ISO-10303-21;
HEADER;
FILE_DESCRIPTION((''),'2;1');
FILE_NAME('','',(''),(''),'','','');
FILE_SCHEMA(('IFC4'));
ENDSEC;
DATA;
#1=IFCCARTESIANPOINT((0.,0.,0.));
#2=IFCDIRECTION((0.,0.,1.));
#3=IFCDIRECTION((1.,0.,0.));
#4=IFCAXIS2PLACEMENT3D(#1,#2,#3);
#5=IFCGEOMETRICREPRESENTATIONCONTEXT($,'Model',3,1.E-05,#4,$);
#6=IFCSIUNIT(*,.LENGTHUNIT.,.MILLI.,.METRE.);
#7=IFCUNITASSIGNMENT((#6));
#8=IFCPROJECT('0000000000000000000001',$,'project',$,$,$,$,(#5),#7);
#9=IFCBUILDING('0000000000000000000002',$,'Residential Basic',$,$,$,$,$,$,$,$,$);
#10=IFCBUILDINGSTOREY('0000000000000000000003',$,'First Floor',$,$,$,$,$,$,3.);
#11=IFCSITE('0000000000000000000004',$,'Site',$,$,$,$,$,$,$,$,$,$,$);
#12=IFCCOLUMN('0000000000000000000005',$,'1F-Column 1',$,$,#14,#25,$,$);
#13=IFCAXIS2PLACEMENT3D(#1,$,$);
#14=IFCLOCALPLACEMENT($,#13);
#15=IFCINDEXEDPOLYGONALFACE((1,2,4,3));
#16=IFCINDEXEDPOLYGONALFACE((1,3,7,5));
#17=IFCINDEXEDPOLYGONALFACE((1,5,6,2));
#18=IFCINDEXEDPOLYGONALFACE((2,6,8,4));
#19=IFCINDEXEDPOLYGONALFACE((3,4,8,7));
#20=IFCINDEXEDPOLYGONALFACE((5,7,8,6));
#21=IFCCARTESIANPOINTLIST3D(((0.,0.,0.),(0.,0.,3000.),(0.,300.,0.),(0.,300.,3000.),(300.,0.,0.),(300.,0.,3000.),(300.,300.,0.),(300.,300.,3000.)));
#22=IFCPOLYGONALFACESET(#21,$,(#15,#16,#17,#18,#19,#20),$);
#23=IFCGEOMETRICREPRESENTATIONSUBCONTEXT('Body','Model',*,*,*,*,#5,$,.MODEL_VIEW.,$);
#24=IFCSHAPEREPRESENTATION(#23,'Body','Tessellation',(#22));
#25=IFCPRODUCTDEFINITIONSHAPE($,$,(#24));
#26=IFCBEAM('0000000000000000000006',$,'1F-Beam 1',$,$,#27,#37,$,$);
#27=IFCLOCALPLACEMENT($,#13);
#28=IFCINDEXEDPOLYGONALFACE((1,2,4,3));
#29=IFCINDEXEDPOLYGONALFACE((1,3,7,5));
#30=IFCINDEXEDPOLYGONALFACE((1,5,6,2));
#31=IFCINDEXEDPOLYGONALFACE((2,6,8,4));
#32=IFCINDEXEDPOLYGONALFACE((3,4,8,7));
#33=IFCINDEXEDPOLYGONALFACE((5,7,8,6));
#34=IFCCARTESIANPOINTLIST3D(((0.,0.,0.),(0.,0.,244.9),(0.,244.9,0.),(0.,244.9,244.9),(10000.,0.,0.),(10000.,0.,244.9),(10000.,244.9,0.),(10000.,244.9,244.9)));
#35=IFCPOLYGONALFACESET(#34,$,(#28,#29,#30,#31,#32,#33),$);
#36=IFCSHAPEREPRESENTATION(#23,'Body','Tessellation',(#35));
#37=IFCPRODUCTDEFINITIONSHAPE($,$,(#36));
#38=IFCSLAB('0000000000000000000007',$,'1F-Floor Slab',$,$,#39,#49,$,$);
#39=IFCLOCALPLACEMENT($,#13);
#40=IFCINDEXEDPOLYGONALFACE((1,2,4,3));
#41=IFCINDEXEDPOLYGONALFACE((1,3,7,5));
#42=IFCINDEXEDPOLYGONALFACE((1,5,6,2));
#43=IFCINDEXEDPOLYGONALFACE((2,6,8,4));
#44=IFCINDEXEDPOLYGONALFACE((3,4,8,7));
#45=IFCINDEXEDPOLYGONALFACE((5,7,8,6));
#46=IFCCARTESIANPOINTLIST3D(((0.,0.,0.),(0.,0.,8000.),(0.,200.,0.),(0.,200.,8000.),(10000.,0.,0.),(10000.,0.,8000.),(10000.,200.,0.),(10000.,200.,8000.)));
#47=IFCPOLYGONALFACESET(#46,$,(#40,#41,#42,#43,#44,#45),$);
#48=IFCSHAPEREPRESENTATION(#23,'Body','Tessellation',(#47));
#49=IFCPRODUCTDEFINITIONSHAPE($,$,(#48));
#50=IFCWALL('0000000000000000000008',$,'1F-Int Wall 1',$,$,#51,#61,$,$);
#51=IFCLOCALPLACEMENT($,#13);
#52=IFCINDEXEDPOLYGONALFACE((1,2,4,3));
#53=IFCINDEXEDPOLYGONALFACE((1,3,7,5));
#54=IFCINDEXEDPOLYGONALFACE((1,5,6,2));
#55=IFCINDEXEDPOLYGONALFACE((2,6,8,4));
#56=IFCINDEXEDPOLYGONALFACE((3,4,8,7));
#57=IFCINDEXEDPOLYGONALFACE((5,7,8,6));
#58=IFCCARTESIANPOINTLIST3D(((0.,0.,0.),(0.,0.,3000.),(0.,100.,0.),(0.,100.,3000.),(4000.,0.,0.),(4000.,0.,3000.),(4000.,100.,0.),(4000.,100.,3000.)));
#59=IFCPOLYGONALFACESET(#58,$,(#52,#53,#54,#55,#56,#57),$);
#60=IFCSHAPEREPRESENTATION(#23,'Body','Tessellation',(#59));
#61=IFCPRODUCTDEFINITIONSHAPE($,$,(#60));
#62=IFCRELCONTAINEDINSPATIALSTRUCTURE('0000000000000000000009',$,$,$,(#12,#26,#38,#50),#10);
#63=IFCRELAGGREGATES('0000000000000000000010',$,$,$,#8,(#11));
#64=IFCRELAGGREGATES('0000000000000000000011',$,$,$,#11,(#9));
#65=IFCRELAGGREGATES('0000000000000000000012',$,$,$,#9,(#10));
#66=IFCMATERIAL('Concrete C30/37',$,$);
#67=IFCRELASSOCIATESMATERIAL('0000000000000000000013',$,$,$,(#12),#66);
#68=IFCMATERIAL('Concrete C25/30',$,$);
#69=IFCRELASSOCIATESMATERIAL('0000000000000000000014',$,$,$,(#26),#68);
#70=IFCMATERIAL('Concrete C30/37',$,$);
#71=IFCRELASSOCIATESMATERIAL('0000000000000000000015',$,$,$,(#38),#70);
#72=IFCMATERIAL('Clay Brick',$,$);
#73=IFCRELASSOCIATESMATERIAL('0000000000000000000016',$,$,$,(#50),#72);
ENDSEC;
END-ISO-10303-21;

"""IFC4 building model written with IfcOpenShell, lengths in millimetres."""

from ifc_helpers import new_model, si_unit, origin_with_axes, context, subcontext, project, spatial, indexed_curve, outline, extrude, material, element, save


model = new_model("IFC4")

# Units and contexts
model_context = context("Model", 3, precision=1e-05, world=origin_with_axes())
body_context = subcontext(model_context, "Body", "Model", "MODEL_VIEW")
ifc_project = project(units=[si_unit("LENGTHUNIT", "METRE", prefix="MILLI")], contexts=[model_context])

# Site, building, storey
site = spatial("IfcSite", under=ifc_project, Name="Site")
building = spatial("IfcBuilding", under=site, Name="Residential Basic")
storey = spatial("IfcBuildingStorey", under=building, Name="First Floor", Elevation=3.0)

# Column
ifc_material_1 = material(Name="Concrete C30/37")
element("IfcColumn", 1, inside=storey, material=ifc_material_1, Name="1F-Column 1", context=body_context, shape_type="SweptSolid", body=[
    extrude(outline(indexed_curve([(0.0, 0.0), (0.0, 300.0), (300.0, 300.0), (300.0, 0.0), (0.0, 0.0)], self_intersect=False)), origin_with_axes(), (0.0, 0.0, 1.0), 3000.0),
])

# Beam
ifc_material_2 = material(Name="Concrete C25/30")
element("IfcBeam", 2, inside=storey, material=ifc_material_2, Name="1F-Beam 1", context=body_context, shape_type="SweptSolid", body=[
    extrude(outline(indexed_curve([(0.0, 0.0), (0.0, 244.9), (10000.0, 244.9), (10000.0, 0.0), (0.0, 0.0)], self_intersect=False)), origin_with_axes(), (0.0, 0.0, 1.0), 244.9),
])

# Slab
ifc_material_3 = material(Name="Concrete C30/37")
element("IfcSlab", 3, inside=storey, material=ifc_material_3, Name="1F-Floor Slab", context=body_context, shape_type="SweptSolid", body=[
    extrude(outline(indexed_curve([(0.0, 0.0), (0.0, 200.0), (10000.0, 200.0), (10000.0, 0.0), (0.0, 0.0)], self_intersect=False)), origin_with_axes(), (0.0, 0.0, 1.0), 8000.0),
])

# Wall
ifc_material_4 = material(Name="Clay Brick")
element("IfcWall", 4, inside=storey, material=ifc_material_4, Name="1F-Int Wall 1", context=body_context, shape_type="SweptSolid", body=[
    extrude(outline(indexed_curve([(0.0, 0.0), (0.0, 100.0), (4000.0, 100.0), (4000.0, 0.0), (0.0, 0.0)], self_intersect=False)), origin_with_axes(), (0.0, 0.0, 1.0), 3000.0),
])

save(model, "model.ifc")
